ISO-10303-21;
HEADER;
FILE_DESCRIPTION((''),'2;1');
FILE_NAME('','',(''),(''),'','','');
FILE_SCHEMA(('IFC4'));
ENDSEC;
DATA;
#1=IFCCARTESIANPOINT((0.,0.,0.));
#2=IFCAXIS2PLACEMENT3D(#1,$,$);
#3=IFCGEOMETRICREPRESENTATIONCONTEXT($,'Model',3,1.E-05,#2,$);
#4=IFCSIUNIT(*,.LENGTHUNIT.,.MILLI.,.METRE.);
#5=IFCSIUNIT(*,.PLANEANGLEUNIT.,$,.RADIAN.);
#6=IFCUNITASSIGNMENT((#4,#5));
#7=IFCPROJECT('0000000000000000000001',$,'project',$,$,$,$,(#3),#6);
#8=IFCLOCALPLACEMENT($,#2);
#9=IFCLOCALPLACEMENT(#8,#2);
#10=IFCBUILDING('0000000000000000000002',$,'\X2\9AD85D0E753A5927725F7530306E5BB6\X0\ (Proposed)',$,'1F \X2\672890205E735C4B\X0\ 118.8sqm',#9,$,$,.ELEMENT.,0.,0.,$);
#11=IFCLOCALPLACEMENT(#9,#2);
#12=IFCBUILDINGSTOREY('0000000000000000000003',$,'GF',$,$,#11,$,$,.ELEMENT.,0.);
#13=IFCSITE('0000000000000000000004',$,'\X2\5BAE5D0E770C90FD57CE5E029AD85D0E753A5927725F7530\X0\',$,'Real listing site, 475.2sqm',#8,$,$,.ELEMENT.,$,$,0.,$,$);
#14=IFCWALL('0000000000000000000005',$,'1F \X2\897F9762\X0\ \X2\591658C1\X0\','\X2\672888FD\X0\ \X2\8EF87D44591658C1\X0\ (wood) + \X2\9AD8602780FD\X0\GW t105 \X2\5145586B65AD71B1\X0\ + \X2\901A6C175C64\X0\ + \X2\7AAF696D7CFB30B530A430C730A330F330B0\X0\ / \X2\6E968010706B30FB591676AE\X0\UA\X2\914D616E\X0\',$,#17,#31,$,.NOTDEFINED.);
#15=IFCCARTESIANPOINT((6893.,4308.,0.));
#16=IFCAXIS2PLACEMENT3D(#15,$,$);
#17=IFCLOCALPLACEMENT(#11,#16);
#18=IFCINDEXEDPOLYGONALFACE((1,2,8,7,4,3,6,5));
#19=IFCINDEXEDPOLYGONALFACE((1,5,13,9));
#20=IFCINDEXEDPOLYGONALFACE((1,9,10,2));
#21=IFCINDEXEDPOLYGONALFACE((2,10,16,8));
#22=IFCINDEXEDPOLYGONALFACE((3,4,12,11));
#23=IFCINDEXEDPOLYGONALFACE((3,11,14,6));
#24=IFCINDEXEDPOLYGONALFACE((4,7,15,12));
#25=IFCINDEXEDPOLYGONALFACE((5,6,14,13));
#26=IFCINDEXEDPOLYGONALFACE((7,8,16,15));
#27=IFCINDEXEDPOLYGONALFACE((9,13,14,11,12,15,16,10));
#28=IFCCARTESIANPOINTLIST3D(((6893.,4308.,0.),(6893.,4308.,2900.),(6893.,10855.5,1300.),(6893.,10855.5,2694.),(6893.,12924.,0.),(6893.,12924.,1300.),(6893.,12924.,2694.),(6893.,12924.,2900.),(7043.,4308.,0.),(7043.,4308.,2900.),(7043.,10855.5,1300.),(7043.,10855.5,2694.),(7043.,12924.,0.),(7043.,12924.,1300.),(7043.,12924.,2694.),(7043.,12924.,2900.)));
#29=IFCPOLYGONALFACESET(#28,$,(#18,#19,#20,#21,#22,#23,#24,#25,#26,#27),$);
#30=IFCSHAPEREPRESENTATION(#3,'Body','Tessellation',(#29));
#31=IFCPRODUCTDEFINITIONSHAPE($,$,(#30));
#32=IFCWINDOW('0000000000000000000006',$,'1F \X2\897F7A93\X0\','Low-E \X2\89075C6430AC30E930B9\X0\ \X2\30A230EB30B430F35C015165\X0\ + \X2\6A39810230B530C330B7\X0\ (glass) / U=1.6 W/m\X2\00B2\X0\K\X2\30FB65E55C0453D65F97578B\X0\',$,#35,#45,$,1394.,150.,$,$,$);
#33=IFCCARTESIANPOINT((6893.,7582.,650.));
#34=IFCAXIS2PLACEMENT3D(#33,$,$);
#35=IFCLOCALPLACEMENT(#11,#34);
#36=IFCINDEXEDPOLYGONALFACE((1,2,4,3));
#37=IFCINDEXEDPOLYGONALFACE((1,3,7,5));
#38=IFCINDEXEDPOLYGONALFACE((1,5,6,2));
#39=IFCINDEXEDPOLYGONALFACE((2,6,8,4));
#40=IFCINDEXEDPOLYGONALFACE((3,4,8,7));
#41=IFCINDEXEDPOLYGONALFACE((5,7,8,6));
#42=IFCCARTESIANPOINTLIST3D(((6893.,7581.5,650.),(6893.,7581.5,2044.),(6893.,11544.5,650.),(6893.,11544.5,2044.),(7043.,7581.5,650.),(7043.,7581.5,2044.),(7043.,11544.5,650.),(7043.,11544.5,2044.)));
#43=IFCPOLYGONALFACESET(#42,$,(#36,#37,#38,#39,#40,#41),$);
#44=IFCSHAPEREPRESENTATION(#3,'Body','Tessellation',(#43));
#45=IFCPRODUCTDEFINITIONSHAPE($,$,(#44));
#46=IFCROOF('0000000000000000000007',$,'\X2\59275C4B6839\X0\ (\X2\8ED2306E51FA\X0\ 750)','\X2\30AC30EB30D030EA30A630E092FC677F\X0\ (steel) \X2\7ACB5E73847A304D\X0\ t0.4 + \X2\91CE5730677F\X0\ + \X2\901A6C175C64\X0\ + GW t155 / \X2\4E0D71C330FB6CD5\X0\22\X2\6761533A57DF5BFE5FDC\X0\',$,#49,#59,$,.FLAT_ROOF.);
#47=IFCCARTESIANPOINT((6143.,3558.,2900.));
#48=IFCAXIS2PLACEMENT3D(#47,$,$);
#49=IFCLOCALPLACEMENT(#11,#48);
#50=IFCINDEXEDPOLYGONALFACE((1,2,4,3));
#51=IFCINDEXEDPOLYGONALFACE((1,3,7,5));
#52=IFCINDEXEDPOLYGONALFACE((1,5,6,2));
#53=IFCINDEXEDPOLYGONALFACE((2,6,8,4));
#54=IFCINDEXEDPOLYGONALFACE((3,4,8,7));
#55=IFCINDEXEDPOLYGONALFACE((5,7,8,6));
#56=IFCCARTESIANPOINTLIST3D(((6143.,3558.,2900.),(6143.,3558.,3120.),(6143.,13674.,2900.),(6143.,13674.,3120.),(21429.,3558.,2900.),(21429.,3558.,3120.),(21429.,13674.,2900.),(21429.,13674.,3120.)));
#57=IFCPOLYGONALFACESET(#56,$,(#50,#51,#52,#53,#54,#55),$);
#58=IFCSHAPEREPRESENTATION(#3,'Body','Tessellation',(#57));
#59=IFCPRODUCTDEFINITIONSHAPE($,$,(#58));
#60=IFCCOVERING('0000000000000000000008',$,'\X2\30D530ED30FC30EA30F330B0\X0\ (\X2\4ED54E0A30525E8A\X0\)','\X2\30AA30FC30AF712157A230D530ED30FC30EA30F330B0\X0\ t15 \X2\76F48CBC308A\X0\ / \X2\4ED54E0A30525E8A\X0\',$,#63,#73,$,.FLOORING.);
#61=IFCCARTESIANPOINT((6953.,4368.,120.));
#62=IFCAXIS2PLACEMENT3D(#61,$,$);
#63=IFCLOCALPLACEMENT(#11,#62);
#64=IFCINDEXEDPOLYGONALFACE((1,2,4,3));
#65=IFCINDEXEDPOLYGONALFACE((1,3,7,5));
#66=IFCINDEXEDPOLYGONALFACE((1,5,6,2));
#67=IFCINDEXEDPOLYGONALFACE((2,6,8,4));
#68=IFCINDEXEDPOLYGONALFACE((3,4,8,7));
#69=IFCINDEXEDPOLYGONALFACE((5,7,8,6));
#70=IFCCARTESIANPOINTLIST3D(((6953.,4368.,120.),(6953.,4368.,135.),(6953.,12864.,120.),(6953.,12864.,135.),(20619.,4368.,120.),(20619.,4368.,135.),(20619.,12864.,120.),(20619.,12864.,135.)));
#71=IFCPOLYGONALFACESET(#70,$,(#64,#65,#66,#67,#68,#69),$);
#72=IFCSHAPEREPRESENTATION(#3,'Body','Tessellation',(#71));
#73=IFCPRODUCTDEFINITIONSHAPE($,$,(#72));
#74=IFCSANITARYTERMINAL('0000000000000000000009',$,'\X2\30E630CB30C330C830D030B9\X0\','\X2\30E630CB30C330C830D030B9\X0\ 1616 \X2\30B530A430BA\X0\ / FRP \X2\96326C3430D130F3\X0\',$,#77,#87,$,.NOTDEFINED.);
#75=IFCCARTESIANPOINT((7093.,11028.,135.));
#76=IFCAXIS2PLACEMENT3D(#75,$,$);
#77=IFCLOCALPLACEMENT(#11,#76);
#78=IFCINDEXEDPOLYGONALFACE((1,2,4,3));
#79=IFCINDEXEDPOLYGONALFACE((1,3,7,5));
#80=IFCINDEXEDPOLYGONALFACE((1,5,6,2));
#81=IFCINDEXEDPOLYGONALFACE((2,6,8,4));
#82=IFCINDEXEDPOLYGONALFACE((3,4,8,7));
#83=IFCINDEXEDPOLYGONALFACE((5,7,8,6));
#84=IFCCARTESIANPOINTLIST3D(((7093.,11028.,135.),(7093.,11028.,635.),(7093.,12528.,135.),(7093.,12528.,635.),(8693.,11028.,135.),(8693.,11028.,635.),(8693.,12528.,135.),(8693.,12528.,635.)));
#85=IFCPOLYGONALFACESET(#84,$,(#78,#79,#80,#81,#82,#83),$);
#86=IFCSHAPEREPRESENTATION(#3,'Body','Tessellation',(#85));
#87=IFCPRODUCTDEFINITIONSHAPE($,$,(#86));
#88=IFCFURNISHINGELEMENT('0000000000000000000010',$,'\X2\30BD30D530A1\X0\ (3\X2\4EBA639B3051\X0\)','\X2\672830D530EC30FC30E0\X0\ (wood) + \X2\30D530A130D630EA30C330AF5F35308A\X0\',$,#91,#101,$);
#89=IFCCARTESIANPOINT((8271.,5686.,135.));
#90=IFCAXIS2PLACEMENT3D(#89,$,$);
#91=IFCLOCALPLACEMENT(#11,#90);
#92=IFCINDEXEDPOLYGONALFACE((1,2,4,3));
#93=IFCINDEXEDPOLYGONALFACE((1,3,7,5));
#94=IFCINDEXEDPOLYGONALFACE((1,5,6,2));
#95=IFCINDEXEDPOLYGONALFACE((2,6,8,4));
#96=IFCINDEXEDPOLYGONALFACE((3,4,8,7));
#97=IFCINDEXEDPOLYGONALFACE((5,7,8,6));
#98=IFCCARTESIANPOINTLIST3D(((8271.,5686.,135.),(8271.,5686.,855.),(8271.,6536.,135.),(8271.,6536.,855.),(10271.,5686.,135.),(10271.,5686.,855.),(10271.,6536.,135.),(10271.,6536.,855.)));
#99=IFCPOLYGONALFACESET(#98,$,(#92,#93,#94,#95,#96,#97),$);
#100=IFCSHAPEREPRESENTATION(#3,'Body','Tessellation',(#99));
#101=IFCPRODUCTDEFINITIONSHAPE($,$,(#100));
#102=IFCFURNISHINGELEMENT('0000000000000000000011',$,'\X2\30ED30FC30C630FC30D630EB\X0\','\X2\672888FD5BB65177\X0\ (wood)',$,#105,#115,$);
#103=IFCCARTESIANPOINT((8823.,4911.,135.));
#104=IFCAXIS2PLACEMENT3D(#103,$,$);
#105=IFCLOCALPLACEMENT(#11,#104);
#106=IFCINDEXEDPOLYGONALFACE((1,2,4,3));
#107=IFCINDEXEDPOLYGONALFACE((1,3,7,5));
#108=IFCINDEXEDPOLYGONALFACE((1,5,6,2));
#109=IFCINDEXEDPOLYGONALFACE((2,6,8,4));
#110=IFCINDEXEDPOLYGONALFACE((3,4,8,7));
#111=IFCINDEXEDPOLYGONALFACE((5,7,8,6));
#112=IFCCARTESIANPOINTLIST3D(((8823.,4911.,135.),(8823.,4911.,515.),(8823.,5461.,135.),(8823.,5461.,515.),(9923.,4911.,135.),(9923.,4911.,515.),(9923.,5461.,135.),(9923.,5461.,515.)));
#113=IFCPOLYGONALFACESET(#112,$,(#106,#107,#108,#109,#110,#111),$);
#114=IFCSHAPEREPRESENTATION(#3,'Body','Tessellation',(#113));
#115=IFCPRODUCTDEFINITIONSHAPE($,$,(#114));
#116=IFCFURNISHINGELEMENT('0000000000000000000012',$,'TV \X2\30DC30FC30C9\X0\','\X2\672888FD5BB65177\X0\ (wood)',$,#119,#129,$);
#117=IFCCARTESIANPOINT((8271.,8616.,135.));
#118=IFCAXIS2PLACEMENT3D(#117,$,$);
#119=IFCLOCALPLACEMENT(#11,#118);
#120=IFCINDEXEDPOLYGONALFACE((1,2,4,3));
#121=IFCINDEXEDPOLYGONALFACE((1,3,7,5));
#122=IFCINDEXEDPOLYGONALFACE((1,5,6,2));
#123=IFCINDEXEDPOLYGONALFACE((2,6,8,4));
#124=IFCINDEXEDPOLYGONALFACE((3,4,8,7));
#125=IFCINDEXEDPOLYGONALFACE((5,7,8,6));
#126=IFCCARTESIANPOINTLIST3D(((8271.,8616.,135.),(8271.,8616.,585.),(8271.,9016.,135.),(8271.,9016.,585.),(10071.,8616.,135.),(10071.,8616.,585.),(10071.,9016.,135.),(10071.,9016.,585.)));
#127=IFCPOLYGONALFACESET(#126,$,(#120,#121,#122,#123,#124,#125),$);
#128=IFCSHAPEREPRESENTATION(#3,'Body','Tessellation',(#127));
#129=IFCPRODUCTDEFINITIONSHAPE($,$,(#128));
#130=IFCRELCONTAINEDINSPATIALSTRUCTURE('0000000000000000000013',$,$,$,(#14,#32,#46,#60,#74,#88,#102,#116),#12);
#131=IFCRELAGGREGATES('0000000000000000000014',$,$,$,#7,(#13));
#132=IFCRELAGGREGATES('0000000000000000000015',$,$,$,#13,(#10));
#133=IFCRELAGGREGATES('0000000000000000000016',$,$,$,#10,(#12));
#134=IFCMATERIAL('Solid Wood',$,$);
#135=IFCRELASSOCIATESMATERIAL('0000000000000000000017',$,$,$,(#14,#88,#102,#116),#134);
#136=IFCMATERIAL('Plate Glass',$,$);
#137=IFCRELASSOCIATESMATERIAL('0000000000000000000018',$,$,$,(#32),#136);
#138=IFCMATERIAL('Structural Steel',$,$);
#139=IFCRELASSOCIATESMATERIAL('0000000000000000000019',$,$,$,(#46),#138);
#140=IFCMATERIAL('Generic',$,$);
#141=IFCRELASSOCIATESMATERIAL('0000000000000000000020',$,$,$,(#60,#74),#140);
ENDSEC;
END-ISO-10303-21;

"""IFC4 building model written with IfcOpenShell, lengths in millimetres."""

from ifc_helpers import new_model, si_unit, frame, frame_2d, origin, place, context, project, spatial, rectangle, extrude, material, element, fill, save


model = new_model("IFC4")

# Units and contexts
model_context = context("Model", 3, precision=1e-05, world=origin())
ifc_project = project(units=[si_unit("LENGTHUNIT", "METRE", prefix="MILLI"), si_unit("PLANEANGLEUNIT", "RADIAN")], contexts=[model_context])

# Site, building, storey
site_placement = place(None, origin())
site = spatial("IfcSite", under=ifc_project, at=site_placement, Name="宮崎県都城市高崎町大牟田", ObjectType="Real listing site, 475.2sqm", CompositionType="ELEMENT", RefElevation=0.0)
building_placement = place(site_placement, origin())
building = spatial("IfcBuilding", under=site, at=building_placement, Name="高崎町大牟田の家 (Proposed)", ObjectType="1F 木造平屋 118.8sqm", CompositionType="ELEMENT", ElevationOfRefHeight=0.0, ElevationOfTerrain=0.0)
storey_placement = place(building_placement, origin())
storey = spatial("IfcBuildingStorey", under=building, at=storey_placement, Name="GF", CompositionType="ELEMENT", Elevation=0.0)

# Shared definitions
ifc_material_1 = material(Name="Solid Wood")

# Shared definitions
ifc_material_2 = material(Name="Plate Glass")

# Wall, opening, window
wall_1_placement = place(storey_placement, frame((6893.0, 4308.0, 0.0)))
wall_1 = element("IfcWall", 1, at=wall_1_placement, inside=storey, material=ifc_material_1, Name="1F 西面 外壁", Description="木製 軸組外壁 (wood) + 高性能GW t105 充填断熱 + 通気層 + 窯業系サイディング / 準耐火・外皮UA配慮", PredefinedType="NOTDEFINED", context=model_context, shape_type="SweptSolid", body=[
    extrude(rectangle(XDim=150.0, YDim=8616.0, at=frame_2d((75.0, 4308.0))), frame((6893.0, 4308.0, 0.0)), (0.0, 0.0, 1.0), 2900.0),
])
opening_1_placement = place(storey_placement, frame((6893.0, 7582.0, 650.0)))
opening_1 = element("IfcOpeningElement", 2, at=opening_1_placement, cuts=wall_1, PredefinedType="NOTDEFINED", context=model_context, shape_type="SweptSolid", body=[
    extrude(rectangle(XDim=150.0, YDim=3963.0, at=frame_2d((75.0, 1981.0))), frame((6893.0, 7582.0, 650.0)), (0.0, 0.0, 1.0), 1394.0),
])
window_1_placement = place(storey_placement, frame((6893.0, 7582.0, 650.0)))
window_1 = element("IfcWindow", 3, at=window_1_placement, inside=storey, material=ifc_material_2, Name="1F 西窓", Description="Low-E 複層ガラス アルゴン封入 + 樹脂サッシ (glass) / U=1.6 W/m²K・日射取得型", OverallHeight=1394.0, OverallWidth=150.0, context=model_context, shape_type="SweptSolid", body=[
    extrude(rectangle(XDim=150.0, YDim=3963.0, at=frame_2d((75.0, 1981.0))), frame((6893.0, 7582.0, 650.0)), (0.0, 0.0, 1.0), 1394.0),
])
fill(opening_1, window_1)

# Roof
ifc_material_3 = material(Name="Structural Steel")
roof_placement = place(storey_placement, frame((6143.0, 3558.0, 2900.0)))
element("IfcRoof", 4, at=roof_placement, inside=storey, material=ifc_material_3, Name="大屋根 (軒の出 750)", Description="ガルバリウム鋼板 (steel) 立平葺き t0.4 + 野地板 + 通気層 + GW t155 / 不燃・法22条区域対応", PredefinedType="FLAT_ROOF", context=model_context, shape_type="SweptSolid", body=[
    extrude(rectangle(XDim=15286.0, YDim=10116.0, at=frame_2d((7643.0, 5058.0))), frame((6143.0, 3558.0, 2900.0)), (0.0, 0.0, 1.0), 220.0),
])

# Covering
ifc_material_4 = material(Name="Generic")
covering_placement = place(storey_placement, frame((6953.0, 4368.0, 120.0)))
element("IfcCovering", 5, at=covering_placement, inside=storey, material=ifc_material_4, Name="フローリング (仕上げ床)", Description="オーク無垢フローリング t15 直貼り / 仕上げ床", PredefinedType="FLOORING", context=model_context, shape_type="SweptSolid", body=[
    extrude(rectangle(XDim=13666.0, YDim=8496.0, at=frame_2d((6833.0, 4248.0))), frame((6953.0, 4368.0, 120.0)), (0.0, 0.0, 1.0), 15.0),
])

# Sanitary terminal
sanitary_terminal_placement = place(storey_placement, frame((7093.0, 11028.0, 135.0)))
element("IfcSanitaryTerminal", 6, at=sanitary_terminal_placement, inside=storey, material=ifc_material_4, Name="ユニットバス", Description="ユニットバス 1616 サイズ / FRP 防水パン", PredefinedType="NOTDEFINED", context=model_context, shape_type="SweptSolid", body=[
    extrude(rectangle(XDim=1600.0, YDim=1500.0, at=frame_2d((800.0, 750.0))), frame((7093.0, 11028.0, 135.0)), (0.0, 0.0, 1.0), 500.0),
])

# Furnishing elements
furnishing_1_placement = place(storey_placement, frame((8271.0, 5686.0, 135.0)))
element("IfcFurnishingElement", 7, at=furnishing_1_placement, inside=storey, material=ifc_material_1, Name="ソファ (3人掛け)", Description="木フレーム (wood) + ファブリック張り", context=model_context, shape_type="SweptSolid", body=[
    extrude(rectangle(XDim=2000.0, YDim=850.0, at=frame_2d((1000.0, 425.0))), frame((8271.0, 5686.0, 135.0)), (0.0, 0.0, 1.0), 720.0),
])
furnishing_2_placement = place(storey_placement, frame((8823.0, 4911.0, 135.0)))
element("IfcFurnishingElement", 8, at=furnishing_2_placement, inside=storey, material=ifc_material_1, Name="ローテーブル", Description="木製家具 (wood)", context=model_context, shape_type="SweptSolid", body=[
    extrude(rectangle(XDim=1100.0, YDim=550.0, at=frame_2d((550.0, 275.0))), frame((8823.0, 4911.0, 135.0)), (0.0, 0.0, 1.0), 380.0),
])
furnishing_3_placement = place(storey_placement, frame((8271.0, 8616.0, 135.0)))
element("IfcFurnishingElement", 9, at=furnishing_3_placement, inside=storey, material=ifc_material_1, Name="TV ボード", Description="木製家具 (wood)", context=model_context, shape_type="SweptSolid", body=[
    extrude(rectangle(XDim=1800.0, YDim=400.0, at=frame_2d((900.0, 200.0))), frame((8271.0, 8616.0, 135.0)), (0.0, 0.0, 1.0), 450.0),
])

save(model, "model.ifc")
